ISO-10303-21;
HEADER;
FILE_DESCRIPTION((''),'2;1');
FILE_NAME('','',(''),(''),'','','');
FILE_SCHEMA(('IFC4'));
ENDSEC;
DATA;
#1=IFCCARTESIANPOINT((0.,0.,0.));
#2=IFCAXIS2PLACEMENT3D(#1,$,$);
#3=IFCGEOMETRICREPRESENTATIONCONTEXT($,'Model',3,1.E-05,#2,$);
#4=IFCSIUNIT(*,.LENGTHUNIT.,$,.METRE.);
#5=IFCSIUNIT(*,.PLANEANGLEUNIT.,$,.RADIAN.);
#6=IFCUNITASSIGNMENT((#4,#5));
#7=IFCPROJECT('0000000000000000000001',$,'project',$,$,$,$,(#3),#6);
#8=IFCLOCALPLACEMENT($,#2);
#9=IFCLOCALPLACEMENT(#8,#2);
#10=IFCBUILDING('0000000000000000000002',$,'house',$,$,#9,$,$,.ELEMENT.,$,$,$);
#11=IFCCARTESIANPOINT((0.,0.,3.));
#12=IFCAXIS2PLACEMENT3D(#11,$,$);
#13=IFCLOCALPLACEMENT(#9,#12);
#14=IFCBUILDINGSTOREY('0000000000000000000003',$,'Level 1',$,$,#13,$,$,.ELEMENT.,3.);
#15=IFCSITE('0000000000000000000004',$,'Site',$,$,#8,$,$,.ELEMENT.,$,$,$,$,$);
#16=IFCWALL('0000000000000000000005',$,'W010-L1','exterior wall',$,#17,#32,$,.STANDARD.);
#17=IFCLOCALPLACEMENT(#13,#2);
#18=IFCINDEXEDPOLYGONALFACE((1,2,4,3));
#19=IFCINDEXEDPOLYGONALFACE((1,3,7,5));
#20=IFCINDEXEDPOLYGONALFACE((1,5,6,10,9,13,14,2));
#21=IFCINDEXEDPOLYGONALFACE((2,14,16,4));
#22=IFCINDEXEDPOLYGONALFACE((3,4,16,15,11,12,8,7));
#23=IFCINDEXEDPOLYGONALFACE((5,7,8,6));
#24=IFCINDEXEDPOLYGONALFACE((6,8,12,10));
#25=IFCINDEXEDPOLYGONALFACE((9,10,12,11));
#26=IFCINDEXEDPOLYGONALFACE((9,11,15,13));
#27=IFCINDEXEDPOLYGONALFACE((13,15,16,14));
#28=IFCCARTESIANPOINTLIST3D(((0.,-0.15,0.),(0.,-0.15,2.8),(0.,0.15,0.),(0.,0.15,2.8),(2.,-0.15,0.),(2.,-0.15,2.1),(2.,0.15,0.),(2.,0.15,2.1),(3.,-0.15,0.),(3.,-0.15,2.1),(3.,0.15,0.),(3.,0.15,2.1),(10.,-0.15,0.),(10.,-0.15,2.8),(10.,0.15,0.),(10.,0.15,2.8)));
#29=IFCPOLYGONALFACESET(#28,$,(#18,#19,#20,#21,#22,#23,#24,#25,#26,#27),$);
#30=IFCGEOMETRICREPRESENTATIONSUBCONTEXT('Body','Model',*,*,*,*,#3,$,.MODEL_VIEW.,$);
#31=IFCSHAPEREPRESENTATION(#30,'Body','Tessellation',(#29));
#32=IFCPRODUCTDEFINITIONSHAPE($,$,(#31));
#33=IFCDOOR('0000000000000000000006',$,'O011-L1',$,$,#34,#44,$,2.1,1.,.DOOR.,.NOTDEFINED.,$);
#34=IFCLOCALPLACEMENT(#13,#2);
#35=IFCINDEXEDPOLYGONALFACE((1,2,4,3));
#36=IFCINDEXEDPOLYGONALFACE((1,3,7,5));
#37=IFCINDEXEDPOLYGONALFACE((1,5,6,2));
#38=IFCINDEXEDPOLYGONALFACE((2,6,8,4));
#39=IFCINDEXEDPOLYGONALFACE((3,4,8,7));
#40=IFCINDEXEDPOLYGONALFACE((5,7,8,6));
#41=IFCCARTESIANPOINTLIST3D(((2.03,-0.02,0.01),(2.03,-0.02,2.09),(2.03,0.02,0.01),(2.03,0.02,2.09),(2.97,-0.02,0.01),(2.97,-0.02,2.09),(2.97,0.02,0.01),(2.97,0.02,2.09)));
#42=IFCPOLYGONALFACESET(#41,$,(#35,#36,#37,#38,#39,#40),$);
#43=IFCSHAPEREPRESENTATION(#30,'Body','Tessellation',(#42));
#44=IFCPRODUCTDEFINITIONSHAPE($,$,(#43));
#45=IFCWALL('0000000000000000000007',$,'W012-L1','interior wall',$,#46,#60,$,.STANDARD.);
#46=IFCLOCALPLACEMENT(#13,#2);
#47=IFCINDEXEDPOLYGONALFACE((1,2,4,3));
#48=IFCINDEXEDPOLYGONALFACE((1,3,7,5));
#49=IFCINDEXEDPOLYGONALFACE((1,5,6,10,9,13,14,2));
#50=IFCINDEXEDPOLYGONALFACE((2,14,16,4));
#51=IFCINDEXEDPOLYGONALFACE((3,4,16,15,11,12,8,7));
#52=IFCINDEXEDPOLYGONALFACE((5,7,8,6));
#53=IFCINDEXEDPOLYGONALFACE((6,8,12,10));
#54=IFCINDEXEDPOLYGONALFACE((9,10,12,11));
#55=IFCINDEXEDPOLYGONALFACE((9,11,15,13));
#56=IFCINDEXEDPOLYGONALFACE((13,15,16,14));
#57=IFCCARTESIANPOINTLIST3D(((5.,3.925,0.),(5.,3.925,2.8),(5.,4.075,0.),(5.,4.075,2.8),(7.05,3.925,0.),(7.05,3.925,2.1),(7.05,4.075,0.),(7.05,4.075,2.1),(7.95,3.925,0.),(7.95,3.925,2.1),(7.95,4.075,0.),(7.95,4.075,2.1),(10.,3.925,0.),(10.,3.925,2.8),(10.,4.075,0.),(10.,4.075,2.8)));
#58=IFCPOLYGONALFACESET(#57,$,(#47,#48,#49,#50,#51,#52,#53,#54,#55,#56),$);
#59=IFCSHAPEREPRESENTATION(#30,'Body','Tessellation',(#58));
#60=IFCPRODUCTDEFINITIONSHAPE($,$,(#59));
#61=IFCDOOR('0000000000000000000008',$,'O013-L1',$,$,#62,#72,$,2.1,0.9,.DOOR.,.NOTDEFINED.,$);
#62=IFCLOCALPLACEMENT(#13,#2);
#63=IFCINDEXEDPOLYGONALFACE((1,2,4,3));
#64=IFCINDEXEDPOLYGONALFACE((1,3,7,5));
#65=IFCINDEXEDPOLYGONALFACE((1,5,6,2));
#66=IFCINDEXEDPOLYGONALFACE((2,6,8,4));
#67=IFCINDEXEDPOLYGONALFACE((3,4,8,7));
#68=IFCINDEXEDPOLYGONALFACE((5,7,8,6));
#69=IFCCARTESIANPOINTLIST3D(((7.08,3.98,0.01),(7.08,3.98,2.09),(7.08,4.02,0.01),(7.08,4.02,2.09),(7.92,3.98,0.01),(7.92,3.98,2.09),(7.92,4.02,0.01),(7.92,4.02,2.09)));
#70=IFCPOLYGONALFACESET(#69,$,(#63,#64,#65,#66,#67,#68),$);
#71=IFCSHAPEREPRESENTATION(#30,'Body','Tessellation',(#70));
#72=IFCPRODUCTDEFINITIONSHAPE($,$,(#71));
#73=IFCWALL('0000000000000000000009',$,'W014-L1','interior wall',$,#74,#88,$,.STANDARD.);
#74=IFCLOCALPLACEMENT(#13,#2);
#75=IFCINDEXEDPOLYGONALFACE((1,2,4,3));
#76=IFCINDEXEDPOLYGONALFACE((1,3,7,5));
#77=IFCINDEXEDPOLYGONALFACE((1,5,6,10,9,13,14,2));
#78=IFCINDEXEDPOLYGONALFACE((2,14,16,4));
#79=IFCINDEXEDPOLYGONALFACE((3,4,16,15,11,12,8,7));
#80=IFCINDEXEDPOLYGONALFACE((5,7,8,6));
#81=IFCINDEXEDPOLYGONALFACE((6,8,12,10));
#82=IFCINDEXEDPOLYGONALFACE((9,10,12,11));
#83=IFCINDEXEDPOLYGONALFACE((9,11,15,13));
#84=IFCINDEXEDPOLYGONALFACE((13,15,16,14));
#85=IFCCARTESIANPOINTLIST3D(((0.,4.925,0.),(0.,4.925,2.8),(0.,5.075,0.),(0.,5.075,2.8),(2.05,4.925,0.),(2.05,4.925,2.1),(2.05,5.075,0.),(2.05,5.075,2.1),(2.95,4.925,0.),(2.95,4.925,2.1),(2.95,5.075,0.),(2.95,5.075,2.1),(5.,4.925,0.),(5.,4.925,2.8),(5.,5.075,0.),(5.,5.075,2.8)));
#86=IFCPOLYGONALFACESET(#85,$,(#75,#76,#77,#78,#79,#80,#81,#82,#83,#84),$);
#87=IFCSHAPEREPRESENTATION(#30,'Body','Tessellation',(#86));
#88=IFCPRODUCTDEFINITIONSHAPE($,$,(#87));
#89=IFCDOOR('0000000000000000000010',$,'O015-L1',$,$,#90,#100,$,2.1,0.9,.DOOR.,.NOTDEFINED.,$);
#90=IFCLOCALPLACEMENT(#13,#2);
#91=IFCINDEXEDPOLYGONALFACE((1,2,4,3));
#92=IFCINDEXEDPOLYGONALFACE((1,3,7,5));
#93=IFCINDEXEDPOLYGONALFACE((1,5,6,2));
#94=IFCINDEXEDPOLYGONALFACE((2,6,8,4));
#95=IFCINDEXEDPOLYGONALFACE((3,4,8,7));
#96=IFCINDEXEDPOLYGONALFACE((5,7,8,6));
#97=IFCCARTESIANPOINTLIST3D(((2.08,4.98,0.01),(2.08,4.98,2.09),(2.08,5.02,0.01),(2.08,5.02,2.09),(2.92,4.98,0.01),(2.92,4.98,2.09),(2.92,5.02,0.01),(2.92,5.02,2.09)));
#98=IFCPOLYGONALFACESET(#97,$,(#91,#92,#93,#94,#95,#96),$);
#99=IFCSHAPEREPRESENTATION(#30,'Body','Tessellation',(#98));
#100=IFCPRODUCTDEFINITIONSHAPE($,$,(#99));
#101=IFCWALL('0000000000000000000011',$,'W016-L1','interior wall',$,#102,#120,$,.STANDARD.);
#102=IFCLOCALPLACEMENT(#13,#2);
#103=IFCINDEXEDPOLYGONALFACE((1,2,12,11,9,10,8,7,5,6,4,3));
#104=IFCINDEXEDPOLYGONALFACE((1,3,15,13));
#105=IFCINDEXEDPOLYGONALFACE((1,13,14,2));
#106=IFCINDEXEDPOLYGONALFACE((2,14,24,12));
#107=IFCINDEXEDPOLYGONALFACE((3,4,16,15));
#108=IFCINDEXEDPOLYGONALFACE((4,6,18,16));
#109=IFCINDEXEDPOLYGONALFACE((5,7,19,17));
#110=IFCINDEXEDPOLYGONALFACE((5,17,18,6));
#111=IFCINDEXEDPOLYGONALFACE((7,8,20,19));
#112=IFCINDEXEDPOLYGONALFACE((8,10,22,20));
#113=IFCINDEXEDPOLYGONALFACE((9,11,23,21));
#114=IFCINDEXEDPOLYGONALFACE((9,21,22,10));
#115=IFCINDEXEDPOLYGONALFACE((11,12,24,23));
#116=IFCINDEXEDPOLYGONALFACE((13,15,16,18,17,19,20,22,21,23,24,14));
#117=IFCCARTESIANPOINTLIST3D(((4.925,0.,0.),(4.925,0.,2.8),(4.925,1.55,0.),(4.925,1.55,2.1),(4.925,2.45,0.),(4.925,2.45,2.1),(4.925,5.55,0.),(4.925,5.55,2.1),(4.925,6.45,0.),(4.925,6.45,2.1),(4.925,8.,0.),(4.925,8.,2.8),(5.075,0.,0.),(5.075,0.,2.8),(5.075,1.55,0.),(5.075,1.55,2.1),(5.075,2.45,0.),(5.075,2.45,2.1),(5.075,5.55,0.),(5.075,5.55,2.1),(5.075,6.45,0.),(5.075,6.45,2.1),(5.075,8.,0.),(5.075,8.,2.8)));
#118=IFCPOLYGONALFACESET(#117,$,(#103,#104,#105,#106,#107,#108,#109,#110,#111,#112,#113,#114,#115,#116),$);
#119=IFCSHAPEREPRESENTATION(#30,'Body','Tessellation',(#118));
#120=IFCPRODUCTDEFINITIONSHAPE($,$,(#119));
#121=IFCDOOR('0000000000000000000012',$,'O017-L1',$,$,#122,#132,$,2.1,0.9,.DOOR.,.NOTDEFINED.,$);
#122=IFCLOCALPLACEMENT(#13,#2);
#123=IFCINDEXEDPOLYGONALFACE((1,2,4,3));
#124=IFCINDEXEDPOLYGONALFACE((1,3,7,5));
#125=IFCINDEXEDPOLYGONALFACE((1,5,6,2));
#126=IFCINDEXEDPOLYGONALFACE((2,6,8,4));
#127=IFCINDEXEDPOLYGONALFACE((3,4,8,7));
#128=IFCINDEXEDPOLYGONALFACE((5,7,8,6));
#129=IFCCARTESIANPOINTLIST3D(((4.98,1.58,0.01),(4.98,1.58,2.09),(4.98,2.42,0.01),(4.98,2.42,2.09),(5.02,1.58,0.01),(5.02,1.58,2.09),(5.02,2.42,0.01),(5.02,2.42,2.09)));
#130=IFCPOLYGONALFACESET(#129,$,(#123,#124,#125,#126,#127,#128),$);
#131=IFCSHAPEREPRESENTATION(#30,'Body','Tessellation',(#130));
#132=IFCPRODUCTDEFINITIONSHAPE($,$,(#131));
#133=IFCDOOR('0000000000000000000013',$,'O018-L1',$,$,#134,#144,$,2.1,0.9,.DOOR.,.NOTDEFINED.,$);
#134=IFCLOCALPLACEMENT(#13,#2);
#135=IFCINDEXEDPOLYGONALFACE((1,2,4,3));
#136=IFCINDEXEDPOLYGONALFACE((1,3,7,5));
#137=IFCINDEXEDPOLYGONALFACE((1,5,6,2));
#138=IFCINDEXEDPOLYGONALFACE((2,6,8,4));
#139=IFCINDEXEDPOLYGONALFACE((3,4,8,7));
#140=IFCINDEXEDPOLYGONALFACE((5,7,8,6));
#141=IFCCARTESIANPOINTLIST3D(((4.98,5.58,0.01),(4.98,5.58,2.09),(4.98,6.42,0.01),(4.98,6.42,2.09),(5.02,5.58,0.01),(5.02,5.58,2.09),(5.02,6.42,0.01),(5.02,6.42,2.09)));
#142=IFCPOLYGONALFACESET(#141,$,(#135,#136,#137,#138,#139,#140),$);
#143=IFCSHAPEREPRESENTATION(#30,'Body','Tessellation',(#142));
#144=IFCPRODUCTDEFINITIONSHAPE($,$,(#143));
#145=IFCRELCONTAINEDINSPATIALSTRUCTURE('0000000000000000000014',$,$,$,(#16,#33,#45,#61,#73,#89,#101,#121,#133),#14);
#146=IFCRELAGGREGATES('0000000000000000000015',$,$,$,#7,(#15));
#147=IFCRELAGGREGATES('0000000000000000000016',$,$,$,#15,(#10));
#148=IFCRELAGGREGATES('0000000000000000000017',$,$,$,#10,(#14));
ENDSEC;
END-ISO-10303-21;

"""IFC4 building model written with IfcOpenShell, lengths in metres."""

from ifc_helpers import new_model, si_unit, frame, origin, origin_2d, place, context, subcontext, project, spatial, rectangle, extrude, element, fill, save


model = new_model("IFC4")

# Units and contexts
model_context = context("Model", 3, precision=1e-05, world=origin())
body_context = subcontext(model_context, "Body", "Model", "MODEL_VIEW")
ifc_project = project(units=[si_unit("LENGTHUNIT", "METRE"), si_unit("PLANEANGLEUNIT", "RADIAN")], contexts=[model_context])

# Site, building, storey
site_placement = place(None, origin())
site = spatial("IfcSite", under=ifc_project, at=site_placement, Name="Site", CompositionType="ELEMENT")
building_placement = place(site_placement, origin())
building = spatial("IfcBuilding", under=site, at=building_placement, Name="house", CompositionType="ELEMENT")
storey_placement = place(building_placement, frame((0.0, 0.0, 3.0)))
storey = spatial("IfcBuildingStorey", under=building, at=storey_placement, Name="Level 1", CompositionType="ELEMENT", Elevation=3.0)

# Walls, openings, doors
wall_1_placement = place(storey_placement, frame((5.0, 0.0, 0.0), z_axis=(0.0, 0.0, 1.0), x_axis=(1.0, 0.0, 0.0)))
wall_1 = element("IfcWall", 1, at=wall_1_placement, inside=storey, Name="W010-L1", Description="exterior wall", PredefinedType="STANDARD", context=body_context, shape_type="SweptSolid", body=[
    extrude(rectangle(XDim=10.0, YDim=0.3, at=origin_2d()), origin(), (0.0, 0.0, 1.0), 2.8),
])
opening_1_placement = place(wall_1_placement, frame((-2.5, 0.0, 0.0)))
opening_1 = element("IfcOpeningElement", 2, at=opening_1_placement, cuts=wall_1, PredefinedType="OPENING", context=body_context, shape_type="SweptSolid", body=[
    extrude(rectangle(XDim=1.0, YDim=0.36, at=origin_2d()), origin(), (0.0, 0.0, 1.0), 2.1),
])
door_1_placement = place(wall_1_placement, frame((-2.5, 0.0, 0.0)))
door_1 = element("IfcDoor", 3, at=door_1_placement, inside=storey, Name="O011-L1", OperationType="NOTDEFINED", OverallHeight=2.1, OverallWidth=1.0, PredefinedType="DOOR", context=body_context, shape_type="SweptSolid", body=[
    extrude(rectangle(XDim=0.94, YDim=0.04, at=origin_2d()), frame((0.0, 0.0, 0.01)), (0.0, 0.0, 1.0), 2.08),
])
fill(opening_1, door_1)
wall_2_placement = place(storey_placement, frame((7.5, 4.0, 0.0), z_axis=(0.0, 0.0, 1.0), x_axis=(1.0, 0.0, 0.0)))
wall_2 = element("IfcWall", 4, at=wall_2_placement, inside=storey, Name="W012-L1", Description="interior wall", PredefinedType="STANDARD", context=body_context, shape_type="SweptSolid", body=[
    extrude(rectangle(XDim=5.0, YDim=0.15, at=origin_2d()), origin(), (0.0, 0.0, 1.0), 2.8),
])
opening_2_placement = place(wall_2_placement, origin())
opening_2 = element("IfcOpeningElement", 5, at=opening_2_placement, cuts=wall_2, PredefinedType="OPENING", context=body_context, shape_type="SweptSolid", body=[
    extrude(rectangle(XDim=0.9, YDim=0.18, at=origin_2d()), origin(), (0.0, 0.0, 1.0), 2.1),
])
door_2_placement = place(wall_2_placement, origin())
door_2 = element("IfcDoor", 6, at=door_2_placement, inside=storey, Name="O013-L1", OperationType="NOTDEFINED", OverallHeight=2.1, OverallWidth=0.9, PredefinedType="DOOR", context=body_context, shape_type="SweptSolid", body=[
    extrude(rectangle(XDim=0.84, YDim=0.04, at=origin_2d()), frame((0.0, 0.0, 0.01)), (0.0, 0.0, 1.0), 2.08),
])
fill(opening_2, door_2)
wall_3_placement = place(storey_placement, frame((2.5, 5.0, 0.0), z_axis=(0.0, 0.0, 1.0), x_axis=(1.0, 0.0, 0.0)))
wall_3 = element("IfcWall", 7, at=wall_3_placement, inside=storey, Name="W014-L1", Description="interior wall", PredefinedType="STANDARD", context=body_context, shape_type="SweptSolid", body=[
    extrude(rectangle(XDim=5.0, YDim=0.15, at=origin_2d()), origin(), (0.0, 0.0, 1.0), 2.8),
])
opening_3_placement = place(wall_3_placement, origin())
opening_3 = element("IfcOpeningElement", 8, at=opening_3_placement, cuts=wall_3, PredefinedType="OPENING", context=body_context, shape_type="SweptSolid", body=[
    extrude(rectangle(XDim=0.9, YDim=0.18, at=origin_2d()), origin(), (0.0, 0.0, 1.0), 2.1),
])
door_3_placement = place(wall_3_placement, origin())
door_3 = element("IfcDoor", 9, at=door_3_placement, inside=storey, Name="O015-L1", OperationType="NOTDEFINED", OverallHeight=2.1, OverallWidth=0.9, PredefinedType="DOOR", context=body_context, shape_type="SweptSolid", body=[
    extrude(rectangle(XDim=0.84, YDim=0.04, at=origin_2d()), frame((0.0, 0.0, 0.01)), (0.0, 0.0, 1.0), 2.08),
])
fill(opening_3, door_3)

# Wall, openings, doors
wall_4_placement = place(storey_placement, frame((5.0, 4.0, 0.0), z_axis=(0.0, 0.0, 1.0), x_axis=(0.0, 1.0, 0.0)))
wall_4 = element("IfcWall", 10, at=wall_4_placement, inside=storey, Name="W016-L1", Description="interior wall", PredefinedType="STANDARD", context=body_context, shape_type="SweptSolid", body=[
    extrude(rectangle(XDim=8.0, YDim=0.15, at=origin_2d()), origin(), (0.0, 0.0, 1.0), 2.8),
])
opening_4_placement = place(wall_4_placement, frame((-2.0, 0.0, 0.0)))
opening_4 = element("IfcOpeningElement", 11, at=opening_4_placement, cuts=wall_4, PredefinedType="OPENING", context=body_context, shape_type="SweptSolid", body=[
    extrude(rectangle(XDim=0.9, YDim=0.18, at=origin_2d()), origin(), (0.0, 0.0, 1.0), 2.1),
])
opening_5_placement = place(wall_4_placement, frame((2.0, 0.0, 0.0)))
opening_5 = element("IfcOpeningElement", 12, at=opening_5_placement, cuts=wall_4, PredefinedType="OPENING", context=body_context, shape_type="SweptSolid", body=[
    extrude(rectangle(XDim=0.9, YDim=0.18, at=origin_2d()), origin(), (0.0, 0.0, 1.0), 2.1),
])
door_4_placement = place(wall_4_placement, frame((-2.0, 0.0, 0.0)))
door_4 = element("IfcDoor", 13, at=door_4_placement, inside=storey, Name="O017-L1", OperationType="NOTDEFINED", OverallHeight=2.1, OverallWidth=0.9, PredefinedType="DOOR", context=body_context, shape_type="SweptSolid", body=[
    extrude(rectangle(XDim=0.84, YDim=0.04, at=origin_2d()), frame((0.0, 0.0, 0.01)), (0.0, 0.0, 1.0), 2.08),
])
fill(opening_4, door_4)
door_5_placement = place(wall_4_placement, frame((2.0, 0.0, 0.0)))
door_5 = element("IfcDoor", 14, at=door_5_placement, inside=storey, Name="O018-L1", OperationType="NOTDEFINED", OverallHeight=2.1, OverallWidth=0.9, PredefinedType="DOOR", context=body_context, shape_type="SweptSolid", body=[
    extrude(rectangle(XDim=0.84, YDim=0.04, at=origin_2d()), frame((0.0, 0.0, 0.01)), (0.0, 0.0, 1.0), 2.08),
])
fill(opening_5, door_5)

save(model, "model.ifc")
